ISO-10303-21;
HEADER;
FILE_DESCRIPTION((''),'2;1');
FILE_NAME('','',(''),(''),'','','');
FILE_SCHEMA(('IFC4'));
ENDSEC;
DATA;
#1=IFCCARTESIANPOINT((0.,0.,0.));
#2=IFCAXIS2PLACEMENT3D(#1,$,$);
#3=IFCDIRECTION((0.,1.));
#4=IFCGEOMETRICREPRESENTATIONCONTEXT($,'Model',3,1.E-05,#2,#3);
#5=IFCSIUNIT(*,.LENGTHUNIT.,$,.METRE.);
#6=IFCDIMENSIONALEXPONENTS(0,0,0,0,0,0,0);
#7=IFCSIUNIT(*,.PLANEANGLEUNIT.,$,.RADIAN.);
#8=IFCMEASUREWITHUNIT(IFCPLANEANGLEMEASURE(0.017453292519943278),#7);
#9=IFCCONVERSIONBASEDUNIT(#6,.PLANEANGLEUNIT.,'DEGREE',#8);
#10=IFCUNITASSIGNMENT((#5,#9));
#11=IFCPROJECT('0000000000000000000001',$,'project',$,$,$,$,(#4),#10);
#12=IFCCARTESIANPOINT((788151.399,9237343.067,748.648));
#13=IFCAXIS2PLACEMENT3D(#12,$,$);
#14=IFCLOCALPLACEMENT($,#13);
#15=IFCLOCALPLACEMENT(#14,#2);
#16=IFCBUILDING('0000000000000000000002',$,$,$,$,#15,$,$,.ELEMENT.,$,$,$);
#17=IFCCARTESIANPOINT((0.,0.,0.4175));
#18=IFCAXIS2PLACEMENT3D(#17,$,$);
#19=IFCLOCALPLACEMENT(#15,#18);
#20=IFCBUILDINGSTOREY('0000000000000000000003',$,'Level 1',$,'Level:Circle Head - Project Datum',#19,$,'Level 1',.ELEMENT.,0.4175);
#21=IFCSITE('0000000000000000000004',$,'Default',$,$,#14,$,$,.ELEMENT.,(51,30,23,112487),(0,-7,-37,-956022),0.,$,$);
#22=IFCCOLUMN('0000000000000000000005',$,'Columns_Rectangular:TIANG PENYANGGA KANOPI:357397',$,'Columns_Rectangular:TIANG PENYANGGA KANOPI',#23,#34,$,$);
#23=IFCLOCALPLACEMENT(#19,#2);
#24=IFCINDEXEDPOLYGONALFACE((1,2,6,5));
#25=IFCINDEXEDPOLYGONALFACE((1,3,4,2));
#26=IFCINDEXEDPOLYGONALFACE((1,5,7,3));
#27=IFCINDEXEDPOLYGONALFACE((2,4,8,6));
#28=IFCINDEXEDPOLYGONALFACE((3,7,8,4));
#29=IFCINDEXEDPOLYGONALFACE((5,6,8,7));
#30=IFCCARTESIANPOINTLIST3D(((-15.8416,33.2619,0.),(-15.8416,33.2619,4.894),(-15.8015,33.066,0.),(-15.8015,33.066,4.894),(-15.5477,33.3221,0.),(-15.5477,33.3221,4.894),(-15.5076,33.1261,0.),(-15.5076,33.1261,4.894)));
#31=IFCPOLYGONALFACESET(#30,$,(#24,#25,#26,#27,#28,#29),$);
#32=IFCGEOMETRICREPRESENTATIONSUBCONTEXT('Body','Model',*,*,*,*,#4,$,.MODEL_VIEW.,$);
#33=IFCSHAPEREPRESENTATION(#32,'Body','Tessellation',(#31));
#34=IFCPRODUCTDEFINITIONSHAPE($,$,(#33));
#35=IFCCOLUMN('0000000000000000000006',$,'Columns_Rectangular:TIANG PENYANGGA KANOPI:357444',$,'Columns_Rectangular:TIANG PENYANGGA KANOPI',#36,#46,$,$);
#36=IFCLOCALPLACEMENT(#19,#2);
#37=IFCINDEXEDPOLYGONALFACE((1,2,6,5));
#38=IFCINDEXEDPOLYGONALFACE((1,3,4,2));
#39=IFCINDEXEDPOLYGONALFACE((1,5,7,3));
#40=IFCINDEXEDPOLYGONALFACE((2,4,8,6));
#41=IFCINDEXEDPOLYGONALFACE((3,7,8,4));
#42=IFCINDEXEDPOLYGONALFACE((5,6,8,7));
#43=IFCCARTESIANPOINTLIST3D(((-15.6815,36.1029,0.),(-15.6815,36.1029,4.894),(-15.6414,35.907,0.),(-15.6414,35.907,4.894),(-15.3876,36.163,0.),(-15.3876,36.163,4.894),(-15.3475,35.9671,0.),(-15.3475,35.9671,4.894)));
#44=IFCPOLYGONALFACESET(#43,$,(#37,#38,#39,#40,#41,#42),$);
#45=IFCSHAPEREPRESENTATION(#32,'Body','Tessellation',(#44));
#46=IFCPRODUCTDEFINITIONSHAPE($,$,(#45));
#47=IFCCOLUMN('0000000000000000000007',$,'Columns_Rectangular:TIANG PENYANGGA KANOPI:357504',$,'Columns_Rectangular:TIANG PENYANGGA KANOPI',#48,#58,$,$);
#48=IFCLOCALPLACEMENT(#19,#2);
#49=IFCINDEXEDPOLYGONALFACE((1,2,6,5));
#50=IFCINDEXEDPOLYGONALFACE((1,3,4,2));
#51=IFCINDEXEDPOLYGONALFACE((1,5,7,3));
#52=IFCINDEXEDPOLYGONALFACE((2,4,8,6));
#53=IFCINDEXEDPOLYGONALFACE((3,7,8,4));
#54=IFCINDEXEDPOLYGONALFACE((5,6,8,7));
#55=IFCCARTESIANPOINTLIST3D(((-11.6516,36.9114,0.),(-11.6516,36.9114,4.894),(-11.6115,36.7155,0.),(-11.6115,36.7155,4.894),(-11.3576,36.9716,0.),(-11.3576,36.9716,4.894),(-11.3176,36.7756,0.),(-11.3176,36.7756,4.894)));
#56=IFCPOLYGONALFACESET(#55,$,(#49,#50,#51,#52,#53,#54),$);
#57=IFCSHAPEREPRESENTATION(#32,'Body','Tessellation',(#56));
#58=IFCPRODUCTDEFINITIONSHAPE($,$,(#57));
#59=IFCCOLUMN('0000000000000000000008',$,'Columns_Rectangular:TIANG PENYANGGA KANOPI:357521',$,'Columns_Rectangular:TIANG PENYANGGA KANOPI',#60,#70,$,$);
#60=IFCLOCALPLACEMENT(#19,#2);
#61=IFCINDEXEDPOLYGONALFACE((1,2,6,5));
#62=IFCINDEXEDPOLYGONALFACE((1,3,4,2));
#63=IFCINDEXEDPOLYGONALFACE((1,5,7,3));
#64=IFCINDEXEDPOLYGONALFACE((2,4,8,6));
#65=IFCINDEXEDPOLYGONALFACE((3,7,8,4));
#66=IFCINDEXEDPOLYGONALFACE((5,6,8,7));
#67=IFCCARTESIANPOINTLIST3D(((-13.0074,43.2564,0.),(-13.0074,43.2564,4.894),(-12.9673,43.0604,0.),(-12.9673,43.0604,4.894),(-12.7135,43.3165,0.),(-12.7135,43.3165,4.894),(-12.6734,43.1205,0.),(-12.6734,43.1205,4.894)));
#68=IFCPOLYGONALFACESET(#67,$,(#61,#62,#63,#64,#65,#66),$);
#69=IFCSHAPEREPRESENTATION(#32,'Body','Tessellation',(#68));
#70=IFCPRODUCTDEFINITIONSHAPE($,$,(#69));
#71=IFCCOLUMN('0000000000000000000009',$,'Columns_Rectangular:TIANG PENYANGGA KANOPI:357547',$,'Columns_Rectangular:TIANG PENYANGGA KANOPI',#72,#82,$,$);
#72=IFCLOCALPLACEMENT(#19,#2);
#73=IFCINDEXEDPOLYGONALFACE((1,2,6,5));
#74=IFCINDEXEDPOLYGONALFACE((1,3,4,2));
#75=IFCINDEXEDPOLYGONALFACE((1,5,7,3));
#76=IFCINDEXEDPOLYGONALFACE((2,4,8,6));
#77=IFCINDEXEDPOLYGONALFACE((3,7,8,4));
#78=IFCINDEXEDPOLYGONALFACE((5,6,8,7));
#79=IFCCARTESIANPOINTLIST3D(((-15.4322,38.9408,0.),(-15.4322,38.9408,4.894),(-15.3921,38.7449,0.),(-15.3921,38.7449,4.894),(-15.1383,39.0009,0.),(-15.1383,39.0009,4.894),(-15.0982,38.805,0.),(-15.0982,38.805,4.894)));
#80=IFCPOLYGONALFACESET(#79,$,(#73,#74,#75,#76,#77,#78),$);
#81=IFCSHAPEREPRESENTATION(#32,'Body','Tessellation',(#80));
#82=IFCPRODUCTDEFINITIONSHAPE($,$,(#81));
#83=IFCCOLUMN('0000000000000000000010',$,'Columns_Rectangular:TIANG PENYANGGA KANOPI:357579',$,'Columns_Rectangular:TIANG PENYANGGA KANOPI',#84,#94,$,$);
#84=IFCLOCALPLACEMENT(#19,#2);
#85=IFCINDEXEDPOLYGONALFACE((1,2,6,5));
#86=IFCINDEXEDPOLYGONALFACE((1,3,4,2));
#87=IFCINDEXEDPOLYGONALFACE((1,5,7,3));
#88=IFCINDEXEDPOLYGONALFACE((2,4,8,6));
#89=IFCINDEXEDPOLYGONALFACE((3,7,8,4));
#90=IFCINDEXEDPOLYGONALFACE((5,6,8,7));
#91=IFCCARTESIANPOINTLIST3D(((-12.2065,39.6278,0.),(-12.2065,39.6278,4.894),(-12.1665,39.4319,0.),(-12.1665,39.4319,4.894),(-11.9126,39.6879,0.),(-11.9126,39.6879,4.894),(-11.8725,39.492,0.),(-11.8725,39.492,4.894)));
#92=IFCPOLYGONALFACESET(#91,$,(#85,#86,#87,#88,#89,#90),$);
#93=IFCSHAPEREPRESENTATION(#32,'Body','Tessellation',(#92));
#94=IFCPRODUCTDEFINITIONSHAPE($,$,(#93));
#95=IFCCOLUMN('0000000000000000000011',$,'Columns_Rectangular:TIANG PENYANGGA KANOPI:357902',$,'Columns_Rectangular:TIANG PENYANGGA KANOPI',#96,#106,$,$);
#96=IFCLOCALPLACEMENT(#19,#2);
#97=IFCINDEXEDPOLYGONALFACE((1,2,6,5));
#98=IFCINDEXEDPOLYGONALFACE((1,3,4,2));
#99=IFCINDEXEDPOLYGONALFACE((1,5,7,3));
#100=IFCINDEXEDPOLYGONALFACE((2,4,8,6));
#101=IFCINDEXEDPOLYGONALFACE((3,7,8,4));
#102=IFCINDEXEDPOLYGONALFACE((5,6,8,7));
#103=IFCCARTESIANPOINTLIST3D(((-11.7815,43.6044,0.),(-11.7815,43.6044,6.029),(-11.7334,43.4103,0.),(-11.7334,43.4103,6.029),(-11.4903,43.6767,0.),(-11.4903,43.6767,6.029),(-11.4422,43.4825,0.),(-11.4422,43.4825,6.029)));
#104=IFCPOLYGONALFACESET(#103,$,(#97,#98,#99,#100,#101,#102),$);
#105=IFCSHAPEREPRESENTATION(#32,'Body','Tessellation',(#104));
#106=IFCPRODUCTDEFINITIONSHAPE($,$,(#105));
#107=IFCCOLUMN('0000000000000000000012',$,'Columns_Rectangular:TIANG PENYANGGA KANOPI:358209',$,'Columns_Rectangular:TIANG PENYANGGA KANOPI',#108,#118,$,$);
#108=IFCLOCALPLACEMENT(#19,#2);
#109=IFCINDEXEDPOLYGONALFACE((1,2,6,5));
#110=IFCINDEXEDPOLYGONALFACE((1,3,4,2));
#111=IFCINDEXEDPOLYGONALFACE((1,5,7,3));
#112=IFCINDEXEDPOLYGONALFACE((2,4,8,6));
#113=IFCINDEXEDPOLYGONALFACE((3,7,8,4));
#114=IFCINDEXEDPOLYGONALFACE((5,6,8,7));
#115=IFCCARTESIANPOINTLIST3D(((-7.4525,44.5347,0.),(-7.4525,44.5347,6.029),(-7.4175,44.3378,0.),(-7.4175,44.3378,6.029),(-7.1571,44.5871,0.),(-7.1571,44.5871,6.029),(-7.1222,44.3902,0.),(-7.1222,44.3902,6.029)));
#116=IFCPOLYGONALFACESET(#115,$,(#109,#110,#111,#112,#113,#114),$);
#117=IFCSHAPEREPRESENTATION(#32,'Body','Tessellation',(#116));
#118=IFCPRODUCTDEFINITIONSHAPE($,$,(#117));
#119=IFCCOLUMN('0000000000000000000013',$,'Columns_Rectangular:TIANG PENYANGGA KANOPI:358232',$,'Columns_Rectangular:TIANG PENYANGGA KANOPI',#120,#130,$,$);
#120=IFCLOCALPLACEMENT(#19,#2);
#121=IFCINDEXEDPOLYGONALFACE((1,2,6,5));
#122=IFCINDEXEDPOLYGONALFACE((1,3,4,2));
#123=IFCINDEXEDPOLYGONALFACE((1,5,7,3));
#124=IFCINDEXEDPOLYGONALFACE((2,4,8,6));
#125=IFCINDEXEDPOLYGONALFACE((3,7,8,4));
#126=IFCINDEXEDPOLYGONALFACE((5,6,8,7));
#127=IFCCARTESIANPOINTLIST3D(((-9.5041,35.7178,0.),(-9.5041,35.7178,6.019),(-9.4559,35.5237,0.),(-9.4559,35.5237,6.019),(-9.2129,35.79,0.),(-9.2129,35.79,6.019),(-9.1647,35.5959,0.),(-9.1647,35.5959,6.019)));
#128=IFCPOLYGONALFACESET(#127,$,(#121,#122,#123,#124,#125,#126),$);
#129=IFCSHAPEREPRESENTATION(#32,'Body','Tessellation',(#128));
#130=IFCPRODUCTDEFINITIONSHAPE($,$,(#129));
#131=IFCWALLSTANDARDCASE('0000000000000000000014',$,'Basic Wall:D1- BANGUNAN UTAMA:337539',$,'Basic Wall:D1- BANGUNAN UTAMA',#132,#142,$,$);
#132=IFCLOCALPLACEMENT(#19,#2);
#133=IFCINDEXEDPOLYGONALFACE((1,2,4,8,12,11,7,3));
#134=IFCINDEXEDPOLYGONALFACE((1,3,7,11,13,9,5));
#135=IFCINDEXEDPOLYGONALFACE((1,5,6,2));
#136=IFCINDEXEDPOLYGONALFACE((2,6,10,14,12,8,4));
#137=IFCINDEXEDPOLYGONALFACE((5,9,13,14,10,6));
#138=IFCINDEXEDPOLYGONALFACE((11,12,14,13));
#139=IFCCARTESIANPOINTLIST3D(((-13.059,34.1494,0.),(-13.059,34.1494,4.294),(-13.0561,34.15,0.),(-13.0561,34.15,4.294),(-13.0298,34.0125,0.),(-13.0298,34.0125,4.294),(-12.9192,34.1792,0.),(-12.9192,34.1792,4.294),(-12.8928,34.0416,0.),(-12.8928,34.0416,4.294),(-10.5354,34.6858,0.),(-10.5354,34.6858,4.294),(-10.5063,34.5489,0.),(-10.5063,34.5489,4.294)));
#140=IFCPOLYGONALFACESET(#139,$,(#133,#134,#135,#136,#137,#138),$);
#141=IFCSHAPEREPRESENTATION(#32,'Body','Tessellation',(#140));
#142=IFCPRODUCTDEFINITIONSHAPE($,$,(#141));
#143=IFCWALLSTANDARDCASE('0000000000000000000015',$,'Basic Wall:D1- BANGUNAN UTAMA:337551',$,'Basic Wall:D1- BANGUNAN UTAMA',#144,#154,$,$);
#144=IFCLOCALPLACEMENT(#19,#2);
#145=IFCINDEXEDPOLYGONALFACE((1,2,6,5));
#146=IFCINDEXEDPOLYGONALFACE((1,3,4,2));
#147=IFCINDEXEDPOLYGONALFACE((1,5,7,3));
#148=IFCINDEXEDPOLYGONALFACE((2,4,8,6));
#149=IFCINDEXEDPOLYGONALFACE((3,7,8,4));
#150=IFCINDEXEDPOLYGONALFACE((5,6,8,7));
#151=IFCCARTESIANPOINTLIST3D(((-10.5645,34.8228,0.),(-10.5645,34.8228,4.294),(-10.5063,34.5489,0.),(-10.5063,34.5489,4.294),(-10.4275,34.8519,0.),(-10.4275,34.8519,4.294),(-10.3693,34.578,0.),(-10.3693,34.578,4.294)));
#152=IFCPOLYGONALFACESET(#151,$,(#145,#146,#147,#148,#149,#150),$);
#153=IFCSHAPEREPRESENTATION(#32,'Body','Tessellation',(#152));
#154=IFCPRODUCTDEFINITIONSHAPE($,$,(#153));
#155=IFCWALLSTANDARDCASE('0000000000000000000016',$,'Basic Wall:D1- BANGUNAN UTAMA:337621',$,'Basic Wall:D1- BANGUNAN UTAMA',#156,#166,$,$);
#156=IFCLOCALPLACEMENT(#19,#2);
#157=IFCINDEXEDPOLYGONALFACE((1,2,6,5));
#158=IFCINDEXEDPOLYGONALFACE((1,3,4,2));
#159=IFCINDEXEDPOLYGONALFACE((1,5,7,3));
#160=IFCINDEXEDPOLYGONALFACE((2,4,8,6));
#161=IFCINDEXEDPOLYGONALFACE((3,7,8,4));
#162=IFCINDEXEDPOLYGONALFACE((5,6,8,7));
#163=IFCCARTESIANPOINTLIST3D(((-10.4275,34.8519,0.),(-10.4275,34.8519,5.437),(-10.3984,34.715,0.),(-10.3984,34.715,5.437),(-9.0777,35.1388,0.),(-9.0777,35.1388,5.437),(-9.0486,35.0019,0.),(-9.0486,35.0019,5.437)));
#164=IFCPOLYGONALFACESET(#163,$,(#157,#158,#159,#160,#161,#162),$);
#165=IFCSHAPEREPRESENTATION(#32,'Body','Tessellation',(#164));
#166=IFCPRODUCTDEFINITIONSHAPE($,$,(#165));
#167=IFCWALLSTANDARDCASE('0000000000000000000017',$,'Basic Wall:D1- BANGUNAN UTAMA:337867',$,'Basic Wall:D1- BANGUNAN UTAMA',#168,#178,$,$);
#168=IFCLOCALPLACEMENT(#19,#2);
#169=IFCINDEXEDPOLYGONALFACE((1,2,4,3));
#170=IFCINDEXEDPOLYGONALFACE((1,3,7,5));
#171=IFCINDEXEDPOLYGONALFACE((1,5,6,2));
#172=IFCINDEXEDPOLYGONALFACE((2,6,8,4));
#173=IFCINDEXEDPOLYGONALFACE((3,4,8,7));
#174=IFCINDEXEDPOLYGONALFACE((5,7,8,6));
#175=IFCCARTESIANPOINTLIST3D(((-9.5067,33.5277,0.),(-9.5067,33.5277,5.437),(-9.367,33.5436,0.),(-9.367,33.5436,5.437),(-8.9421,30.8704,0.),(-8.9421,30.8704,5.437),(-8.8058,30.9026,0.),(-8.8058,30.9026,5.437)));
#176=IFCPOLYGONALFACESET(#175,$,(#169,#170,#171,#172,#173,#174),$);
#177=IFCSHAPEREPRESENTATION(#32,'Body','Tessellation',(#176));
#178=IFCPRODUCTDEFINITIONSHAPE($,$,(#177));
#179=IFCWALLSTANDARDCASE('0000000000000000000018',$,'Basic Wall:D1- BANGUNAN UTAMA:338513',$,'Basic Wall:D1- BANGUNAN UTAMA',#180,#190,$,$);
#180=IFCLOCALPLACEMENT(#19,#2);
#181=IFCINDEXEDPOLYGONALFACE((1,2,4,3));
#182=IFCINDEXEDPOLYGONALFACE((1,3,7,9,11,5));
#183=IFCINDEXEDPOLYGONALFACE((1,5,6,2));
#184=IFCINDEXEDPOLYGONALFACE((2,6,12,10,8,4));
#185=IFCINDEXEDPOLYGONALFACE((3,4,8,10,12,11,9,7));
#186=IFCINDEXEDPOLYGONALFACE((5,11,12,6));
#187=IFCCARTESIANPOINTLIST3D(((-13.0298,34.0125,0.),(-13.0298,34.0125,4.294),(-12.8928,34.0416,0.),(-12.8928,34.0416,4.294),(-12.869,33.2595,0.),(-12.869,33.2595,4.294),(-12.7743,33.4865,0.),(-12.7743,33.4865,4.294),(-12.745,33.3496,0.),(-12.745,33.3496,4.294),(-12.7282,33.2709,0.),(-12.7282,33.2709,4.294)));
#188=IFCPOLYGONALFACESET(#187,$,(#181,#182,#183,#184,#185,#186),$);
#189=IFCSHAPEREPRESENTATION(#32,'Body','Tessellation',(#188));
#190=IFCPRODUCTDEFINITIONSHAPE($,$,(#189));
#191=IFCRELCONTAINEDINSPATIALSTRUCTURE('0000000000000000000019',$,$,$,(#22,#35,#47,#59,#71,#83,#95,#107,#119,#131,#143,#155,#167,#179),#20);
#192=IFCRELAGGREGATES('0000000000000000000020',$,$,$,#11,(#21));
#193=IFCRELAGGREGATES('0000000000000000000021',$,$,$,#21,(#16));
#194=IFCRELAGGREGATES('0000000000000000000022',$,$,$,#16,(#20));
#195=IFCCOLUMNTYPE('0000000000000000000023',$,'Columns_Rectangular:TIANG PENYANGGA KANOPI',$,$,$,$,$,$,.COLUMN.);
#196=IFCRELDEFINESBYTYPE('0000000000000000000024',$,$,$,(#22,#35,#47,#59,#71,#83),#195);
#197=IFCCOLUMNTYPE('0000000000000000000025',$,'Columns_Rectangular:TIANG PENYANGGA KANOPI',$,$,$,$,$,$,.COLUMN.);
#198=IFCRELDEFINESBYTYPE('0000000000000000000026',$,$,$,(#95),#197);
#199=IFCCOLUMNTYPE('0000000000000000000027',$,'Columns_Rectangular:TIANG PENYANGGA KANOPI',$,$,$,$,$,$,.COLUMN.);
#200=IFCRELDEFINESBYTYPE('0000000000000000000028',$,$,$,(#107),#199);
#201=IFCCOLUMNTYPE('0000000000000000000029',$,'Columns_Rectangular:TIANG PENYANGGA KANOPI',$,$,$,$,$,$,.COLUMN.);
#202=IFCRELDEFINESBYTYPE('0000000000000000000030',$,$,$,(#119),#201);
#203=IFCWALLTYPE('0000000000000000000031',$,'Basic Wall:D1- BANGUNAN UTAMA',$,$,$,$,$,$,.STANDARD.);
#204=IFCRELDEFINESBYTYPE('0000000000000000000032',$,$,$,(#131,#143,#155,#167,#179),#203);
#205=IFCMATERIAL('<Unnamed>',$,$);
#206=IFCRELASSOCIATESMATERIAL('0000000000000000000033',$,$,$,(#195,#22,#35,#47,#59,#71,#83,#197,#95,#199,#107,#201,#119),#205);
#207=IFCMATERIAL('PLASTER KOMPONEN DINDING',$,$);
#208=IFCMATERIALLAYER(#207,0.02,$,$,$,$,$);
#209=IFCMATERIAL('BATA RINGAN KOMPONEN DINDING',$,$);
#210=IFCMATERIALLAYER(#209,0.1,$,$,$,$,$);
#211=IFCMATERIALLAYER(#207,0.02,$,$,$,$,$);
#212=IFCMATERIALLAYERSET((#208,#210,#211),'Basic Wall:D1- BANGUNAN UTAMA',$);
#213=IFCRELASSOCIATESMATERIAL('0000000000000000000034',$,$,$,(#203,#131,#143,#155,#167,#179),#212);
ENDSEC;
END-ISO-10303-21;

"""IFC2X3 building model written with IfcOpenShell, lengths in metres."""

from ifc_helpers import new_model, entity, si_unit, converted_unit, direction, frame, frame_2d, origin, origin_2d_with_axis, place, context, subcontext, project, spatial, polyline, rectangle, outline, extrude, source, transform, mapped, material, layer, layer_set, layer_usage, type_object, type_shapes, element, save


model = new_model("IFC2X3")

# Units and contexts
model_context = context("Model", 3, precision=1e-05, world=origin(), true_north=direction((0.0, 1.0)))
body_context = subcontext(model_context, "Body", "Model", "MODEL_VIEW")
ifc_project = project(units=[si_unit("LENGTHUNIT", "METRE"), converted_unit("PLANEANGLEUNIT", "DEGREE", entity("IfcPlaneAngleMeasure", 0.017453292519943278), si_unit("PLANEANGLEUNIT", "RADIAN"), dimensions=[0, 0, 0, 0, 0, 0, 0])], contexts=[model_context])

# Site, building, storey
site_placement = place(None, frame((788151.399, 9237343.067, 748.648)))
site = spatial("IfcSite", under=ifc_project, at=site_placement, Name="Default", CompositionType="ELEMENT", RefLatitude=(51, 30, 23, 112487), RefLongitude=(0, -7, -37, -956022), RefElevation=0.0)
building_placement = place(site_placement, origin())
building = spatial("IfcBuilding", under=site, at=building_placement, CompositionType="ELEMENT")
storey_placement = place(building_placement, frame((0.0, 0.0, 0.4175)))
storey = spatial("IfcBuildingStorey", under=building, at=storey_placement, Name="Level 1", ObjectType="Level:Circle Head - Project Datum", LongName="Level 1", CompositionType="ELEMENT", Elevation=0.4175)

# Columns
ifc_material_1 = material(Name="<Unnamed>")
column_type_1 = type_object("IfcColumnType", Name="Columns_Rectangular:TIANG PENYANGGA KANOPI", PredefinedType="COLUMN", material=ifc_material_1)
shared_shape_1 = source(origin(), body_context, "Body", "SweptSolid", [
    extrude(rectangle(XDim=0.3, YDim=0.2, at=origin_2d_with_axis()), frame((0.0, 0.0, 0.4175), z_axis=(0.0, 0.0, 1.0), x_axis=(-1.0, 0.0, 0.0)), (0.0, 0.0, 1.0), 4.894),
])
type_shapes(column_type_1, [shared_shape_1])
for number, where, z_axis, x_axis, name in (
    (1, (-15.6746, 33.194, -0.4175), (0.0, 0.0, 1.0), (0.979715, 0.200396, 0.0), "Columns_Rectangular:TIANG PENYANGGA KANOPI:357397"),
    (2, (-15.5145, 36.035, -0.4175), (0.0, 0.0, 1.0), (0.979715, 0.200396, 0.0), "Columns_Rectangular:TIANG PENYANGGA KANOPI:357444"),
    (3, (-11.4846, 36.8435, -0.4175), (0.0, 0.0, 1.0), (0.979715, 0.200396, 0.0), "Columns_Rectangular:TIANG PENYANGGA KANOPI:357504"),
    (4, (-12.8404, 43.1885, -0.4175), (0.0, 0.0, 1.0), (0.979715, 0.200396, 0.0), "Columns_Rectangular:TIANG PENYANGGA KANOPI:357521"),
    (5, (-15.2652, 38.8729, -0.4175), (0.0, 0.0, 1.0), (0.979715, 0.200396, 0.0), "Columns_Rectangular:TIANG PENYANGGA KANOPI:357547"),
    (6, (-12.0395, 39.5599, -0.4175), (0.0, 0.0, 1.0), (0.979715, 0.200396, 0.0), "Columns_Rectangular:TIANG PENYANGGA KANOPI:357579"),
):
    element("IfcColumn", number, at=place(storey_placement, frame(where, z_axis=z_axis, x_axis=x_axis)), inside=storey, type_object=column_type_1, material=ifc_material_1, Name=name, ObjectType="Columns_Rectangular:TIANG PENYANGGA KANOPI", context=body_context, shape_type="MappedRepresentation", body=[
        mapped(shared_shape_1, transform((0.0, 0.0, 0.0), scale=1.0)),
    ])
column_type_2 = type_object("IfcColumnType", Name="Columns_Rectangular:TIANG PENYANGGA KANOPI", PredefinedType="COLUMN", material=ifc_material_1)
shared_shape_2 = source(origin(), body_context, "Body", "SweptSolid", [
    extrude(rectangle(XDim=0.3, YDim=0.2, at=origin_2d_with_axis()), frame((0.0, 0.0, 0.4175), z_axis=(0.0, 0.0, 1.0), x_axis=(-1.0, 0.0, 0.0)), (0.0, 0.0, 1.0), 6.029),
])
type_shapes(column_type_2, [shared_shape_2])
column_1_placement = place(storey_placement, frame((-11.6118, 43.5435, -0.4175), z_axis=(0.0, 0.0, 1.0), x_axis=(0.970587, 0.240752, 0.0)))
element("IfcColumn", 7, at=column_1_placement, inside=storey, type_object=column_type_2, material=ifc_material_1, Name="Columns_Rectangular:TIANG PENYANGGA KANOPI:357902", ObjectType="Columns_Rectangular:TIANG PENYANGGA KANOPI", context=body_context, shape_type="MappedRepresentation", body=[
    mapped(shared_shape_2, transform((0.0, 0.0, 0.0), scale=1.0)),
])
column_type_3 = type_object("IfcColumnType", Name="Columns_Rectangular:TIANG PENYANGGA KANOPI", PredefinedType="COLUMN", material=ifc_material_1)
shared_shape_3 = source(origin(), body_context, "Body", "SweptSolid", [
    extrude(rectangle(XDim=0.2, YDim=0.3, at=origin_2d_with_axis()), frame((0.0, 0.0, 0.4175), z_axis=(0.0, 0.0, 1.0), x_axis=(0.0, 1.0, 0.0)), (0.0, 0.0, 1.0), 6.029),
])
type_shapes(column_type_3, [shared_shape_3])
column_2_placement = place(storey_placement, frame((-7.2873, 44.4625, -0.4175), z_axis=(0.0, 0.0, 1.0), x_axis=(-0.984615, -0.174737, 0.0)))
element("IfcColumn", 8, at=column_2_placement, inside=storey, type_object=column_type_3, material=ifc_material_1, Name="Columns_Rectangular:TIANG PENYANGGA KANOPI:358209", ObjectType="Columns_Rectangular:TIANG PENYANGGA KANOPI", context=body_context, shape_type="MappedRepresentation", body=[
    mapped(shared_shape_3, transform((0.0, 0.0, 0.0), scale=1.0)),
])
column_type_4 = type_object("IfcColumnType", Name="Columns_Rectangular:TIANG PENYANGGA KANOPI", PredefinedType="COLUMN", material=ifc_material_1)
shared_shape_4 = source(origin(), body_context, "Body", "SweptSolid", [
    extrude(rectangle(XDim=0.3, YDim=0.2, at=origin_2d_with_axis()), frame((0.0, 0.0, 0.4175), z_axis=(0.0, 0.0, 1.0), x_axis=(-1.0, 0.0, 0.0)), (0.0, 0.0, 1.0), 6.019),
])
type_shapes(column_type_4, [shared_shape_4])
column_3_placement = place(storey_placement, frame((-9.3344, 35.6569, -0.4175), z_axis=(0.0, 0.0, 1.0), x_axis=(0.970587, 0.240752, 0.0)))
element("IfcColumn", 9, at=column_3_placement, inside=storey, type_object=column_type_4, material=ifc_material_1, Name="Columns_Rectangular:TIANG PENYANGGA KANOPI:358232", ObjectType="Columns_Rectangular:TIANG PENYANGGA KANOPI", context=body_context, shape_type="MappedRepresentation", body=[
    mapped(shared_shape_4, transform((0.0, 0.0, 0.0), scale=1.0)),
])

# Walls
ifc_material_2 = material(Name="PLASTER KOMPONEN DINDING")
ifc_layer_1 = layer(ifc_material_2, 0.02)
ifc_material_3 = material(Name="BATA RINGAN KOMPONEN DINDING")
ifc_layer_2 = layer(ifc_material_3, 0.1)
ifc_layer_3 = layer(ifc_material_2, 0.02)
ifc_layer_set = layer_set([ifc_layer_1, ifc_layer_2, ifc_layer_3], Name="Basic Wall:D1- BANGUNAN UTAMA")
ifc_layer_usage_1 = layer_usage(ifc_layer_set, "AXIS2", "NEGATIVE", 0.07)
wall_type = type_object("IfcWallType", Name="Basic Wall:D1- BANGUNAN UTAMA", PredefinedType="STANDARD", material=ifc_layer_set)
wall_1_placement = place(storey_placement, frame((-13.0444, 34.081, 0.0), z_axis=(0.0, 0.0, 1.0), x_axis=(0.978148, 0.207912, 0.0)))
element("IfcWallStandardCase", 10, at=wall_1_placement, inside=storey, type_object=wall_type, material=ifc_layer_usage_1, Name="Basic Wall:D1- BANGUNAN UTAMA:337539", ObjectType="Basic Wall:D1- BANGUNAN UTAMA", context=body_context, shape_type="SweptSolid", body=[
    extrude(outline(polyline([(2.58, -0.07), (2.58, 0.07), (0.1429, 0.07), (0.0029, 0.07), (0.0, 0.07), (0.0001, -0.07), (0.1401, -0.07), (2.58, -0.07)])), origin(), (0.0, 0.0, 1.0), 4.294),
])
ifc_layer_usage_2 = layer_usage(ifc_layer_set, "AXIS2", "NEGATIVE", 0.07)
wall_2_placement = place(storey_placement, frame((-10.4378, 34.5635, 0.0), z_axis=(0.0, 0.0, 1.0), x_axis=(-0.207912, 0.978148, 0.0)))
element("IfcWallStandardCase", 11, at=wall_2_placement, inside=storey, type_object=wall_type, material=ifc_layer_usage_2, Name="Basic Wall:D1- BANGUNAN UTAMA:337551", ObjectType="Basic Wall:D1- BANGUNAN UTAMA", context=body_context, shape_type="SweptSolid", body=[
    extrude(rectangle(XDim=0.28, YDim=0.14, at=frame_2d((0.14, 0.0), x_axis=(-1.0, 0.0))), origin(), (0.0, 0.0, 1.0), 4.294),
])
ifc_layer_usage_3 = layer_usage(ifc_layer_set, "AXIS2", "NEGATIVE", 0.07)
wall_3_placement = place(storey_placement, frame((-10.413, 34.7834, 0.0), z_axis=(0.0, 0.0, 1.0), x_axis=(0.978148, 0.207912, 0.0)))
element("IfcWallStandardCase", 12, at=wall_3_placement, inside=storey, type_object=wall_type, material=ifc_layer_usage_3, Name="Basic Wall:D1- BANGUNAN UTAMA:337621", ObjectType="Basic Wall:D1- BANGUNAN UTAMA", context=body_context, shape_type="SweptSolid", body=[
    extrude(rectangle(XDim=1.38, YDim=0.14, at=frame_2d((0.69, 0.0), x_axis=(-1.0, 0.0))), origin(), (0.0, 0.0, 1.0), 5.437),
])
ifc_layer_usage_4 = layer_usage(ifc_layer_set, "AXIS2", "NEGATIVE", 0.07)
wall_4_placement = place(storey_placement, frame((-9.4383, 33.5422, 0.0), z_axis=(0.0, 0.0, 1.0), x_axis=(0.207863, -0.978158, 0.0)))
element("IfcWallStandardCase", 13, at=wall_4_placement, inside=storey, type_object=wall_type, material=ifc_layer_usage_4, Name="Basic Wall:D1- BANGUNAN UTAMA:337867", ObjectType="Basic Wall:D1- BANGUNAN UTAMA", context=body_context, shape_type="SweptSolid", body=[
    extrude(outline(polyline([(2.7165, -0.07), (2.7135, 0.07), (0.0135, 0.07), (0.0, -0.07), (2.7165, -0.07)])), origin(), (0.0, 0.0, 1.0), 5.437),
])
ifc_layer_usage_5 = layer_usage(ifc_layer_set, "AXIS2", "NEGATIVE", 0.07)
wall_5_placement = place(storey_placement, frame((-12.7967, 33.2563, 0.0), z_axis=(0.0, 0.0, 1.0), x_axis=(-0.208828, 0.977952, 0.0)))
element("IfcWallStandardCase", 14, at=wall_5_placement, inside=storey, type_object=wall_type, material=ifc_layer_usage_5, Name="Basic Wall:D1- BANGUNAN UTAMA:338513", ObjectType="Basic Wall:D1- BANGUNAN UTAMA", context=body_context, shape_type="SweptSolid", body=[
    extrude(outline(polyline([(0.7881, -0.07), (0.7882, 0.07), (0.0182, 0.07), (0.0, -0.07), (0.0804, -0.07), (0.2204, -0.07), (0.7881, -0.07)])), origin(), (0.0, 0.0, 1.0), 4.294),
])

save(model, "model.ifc")
